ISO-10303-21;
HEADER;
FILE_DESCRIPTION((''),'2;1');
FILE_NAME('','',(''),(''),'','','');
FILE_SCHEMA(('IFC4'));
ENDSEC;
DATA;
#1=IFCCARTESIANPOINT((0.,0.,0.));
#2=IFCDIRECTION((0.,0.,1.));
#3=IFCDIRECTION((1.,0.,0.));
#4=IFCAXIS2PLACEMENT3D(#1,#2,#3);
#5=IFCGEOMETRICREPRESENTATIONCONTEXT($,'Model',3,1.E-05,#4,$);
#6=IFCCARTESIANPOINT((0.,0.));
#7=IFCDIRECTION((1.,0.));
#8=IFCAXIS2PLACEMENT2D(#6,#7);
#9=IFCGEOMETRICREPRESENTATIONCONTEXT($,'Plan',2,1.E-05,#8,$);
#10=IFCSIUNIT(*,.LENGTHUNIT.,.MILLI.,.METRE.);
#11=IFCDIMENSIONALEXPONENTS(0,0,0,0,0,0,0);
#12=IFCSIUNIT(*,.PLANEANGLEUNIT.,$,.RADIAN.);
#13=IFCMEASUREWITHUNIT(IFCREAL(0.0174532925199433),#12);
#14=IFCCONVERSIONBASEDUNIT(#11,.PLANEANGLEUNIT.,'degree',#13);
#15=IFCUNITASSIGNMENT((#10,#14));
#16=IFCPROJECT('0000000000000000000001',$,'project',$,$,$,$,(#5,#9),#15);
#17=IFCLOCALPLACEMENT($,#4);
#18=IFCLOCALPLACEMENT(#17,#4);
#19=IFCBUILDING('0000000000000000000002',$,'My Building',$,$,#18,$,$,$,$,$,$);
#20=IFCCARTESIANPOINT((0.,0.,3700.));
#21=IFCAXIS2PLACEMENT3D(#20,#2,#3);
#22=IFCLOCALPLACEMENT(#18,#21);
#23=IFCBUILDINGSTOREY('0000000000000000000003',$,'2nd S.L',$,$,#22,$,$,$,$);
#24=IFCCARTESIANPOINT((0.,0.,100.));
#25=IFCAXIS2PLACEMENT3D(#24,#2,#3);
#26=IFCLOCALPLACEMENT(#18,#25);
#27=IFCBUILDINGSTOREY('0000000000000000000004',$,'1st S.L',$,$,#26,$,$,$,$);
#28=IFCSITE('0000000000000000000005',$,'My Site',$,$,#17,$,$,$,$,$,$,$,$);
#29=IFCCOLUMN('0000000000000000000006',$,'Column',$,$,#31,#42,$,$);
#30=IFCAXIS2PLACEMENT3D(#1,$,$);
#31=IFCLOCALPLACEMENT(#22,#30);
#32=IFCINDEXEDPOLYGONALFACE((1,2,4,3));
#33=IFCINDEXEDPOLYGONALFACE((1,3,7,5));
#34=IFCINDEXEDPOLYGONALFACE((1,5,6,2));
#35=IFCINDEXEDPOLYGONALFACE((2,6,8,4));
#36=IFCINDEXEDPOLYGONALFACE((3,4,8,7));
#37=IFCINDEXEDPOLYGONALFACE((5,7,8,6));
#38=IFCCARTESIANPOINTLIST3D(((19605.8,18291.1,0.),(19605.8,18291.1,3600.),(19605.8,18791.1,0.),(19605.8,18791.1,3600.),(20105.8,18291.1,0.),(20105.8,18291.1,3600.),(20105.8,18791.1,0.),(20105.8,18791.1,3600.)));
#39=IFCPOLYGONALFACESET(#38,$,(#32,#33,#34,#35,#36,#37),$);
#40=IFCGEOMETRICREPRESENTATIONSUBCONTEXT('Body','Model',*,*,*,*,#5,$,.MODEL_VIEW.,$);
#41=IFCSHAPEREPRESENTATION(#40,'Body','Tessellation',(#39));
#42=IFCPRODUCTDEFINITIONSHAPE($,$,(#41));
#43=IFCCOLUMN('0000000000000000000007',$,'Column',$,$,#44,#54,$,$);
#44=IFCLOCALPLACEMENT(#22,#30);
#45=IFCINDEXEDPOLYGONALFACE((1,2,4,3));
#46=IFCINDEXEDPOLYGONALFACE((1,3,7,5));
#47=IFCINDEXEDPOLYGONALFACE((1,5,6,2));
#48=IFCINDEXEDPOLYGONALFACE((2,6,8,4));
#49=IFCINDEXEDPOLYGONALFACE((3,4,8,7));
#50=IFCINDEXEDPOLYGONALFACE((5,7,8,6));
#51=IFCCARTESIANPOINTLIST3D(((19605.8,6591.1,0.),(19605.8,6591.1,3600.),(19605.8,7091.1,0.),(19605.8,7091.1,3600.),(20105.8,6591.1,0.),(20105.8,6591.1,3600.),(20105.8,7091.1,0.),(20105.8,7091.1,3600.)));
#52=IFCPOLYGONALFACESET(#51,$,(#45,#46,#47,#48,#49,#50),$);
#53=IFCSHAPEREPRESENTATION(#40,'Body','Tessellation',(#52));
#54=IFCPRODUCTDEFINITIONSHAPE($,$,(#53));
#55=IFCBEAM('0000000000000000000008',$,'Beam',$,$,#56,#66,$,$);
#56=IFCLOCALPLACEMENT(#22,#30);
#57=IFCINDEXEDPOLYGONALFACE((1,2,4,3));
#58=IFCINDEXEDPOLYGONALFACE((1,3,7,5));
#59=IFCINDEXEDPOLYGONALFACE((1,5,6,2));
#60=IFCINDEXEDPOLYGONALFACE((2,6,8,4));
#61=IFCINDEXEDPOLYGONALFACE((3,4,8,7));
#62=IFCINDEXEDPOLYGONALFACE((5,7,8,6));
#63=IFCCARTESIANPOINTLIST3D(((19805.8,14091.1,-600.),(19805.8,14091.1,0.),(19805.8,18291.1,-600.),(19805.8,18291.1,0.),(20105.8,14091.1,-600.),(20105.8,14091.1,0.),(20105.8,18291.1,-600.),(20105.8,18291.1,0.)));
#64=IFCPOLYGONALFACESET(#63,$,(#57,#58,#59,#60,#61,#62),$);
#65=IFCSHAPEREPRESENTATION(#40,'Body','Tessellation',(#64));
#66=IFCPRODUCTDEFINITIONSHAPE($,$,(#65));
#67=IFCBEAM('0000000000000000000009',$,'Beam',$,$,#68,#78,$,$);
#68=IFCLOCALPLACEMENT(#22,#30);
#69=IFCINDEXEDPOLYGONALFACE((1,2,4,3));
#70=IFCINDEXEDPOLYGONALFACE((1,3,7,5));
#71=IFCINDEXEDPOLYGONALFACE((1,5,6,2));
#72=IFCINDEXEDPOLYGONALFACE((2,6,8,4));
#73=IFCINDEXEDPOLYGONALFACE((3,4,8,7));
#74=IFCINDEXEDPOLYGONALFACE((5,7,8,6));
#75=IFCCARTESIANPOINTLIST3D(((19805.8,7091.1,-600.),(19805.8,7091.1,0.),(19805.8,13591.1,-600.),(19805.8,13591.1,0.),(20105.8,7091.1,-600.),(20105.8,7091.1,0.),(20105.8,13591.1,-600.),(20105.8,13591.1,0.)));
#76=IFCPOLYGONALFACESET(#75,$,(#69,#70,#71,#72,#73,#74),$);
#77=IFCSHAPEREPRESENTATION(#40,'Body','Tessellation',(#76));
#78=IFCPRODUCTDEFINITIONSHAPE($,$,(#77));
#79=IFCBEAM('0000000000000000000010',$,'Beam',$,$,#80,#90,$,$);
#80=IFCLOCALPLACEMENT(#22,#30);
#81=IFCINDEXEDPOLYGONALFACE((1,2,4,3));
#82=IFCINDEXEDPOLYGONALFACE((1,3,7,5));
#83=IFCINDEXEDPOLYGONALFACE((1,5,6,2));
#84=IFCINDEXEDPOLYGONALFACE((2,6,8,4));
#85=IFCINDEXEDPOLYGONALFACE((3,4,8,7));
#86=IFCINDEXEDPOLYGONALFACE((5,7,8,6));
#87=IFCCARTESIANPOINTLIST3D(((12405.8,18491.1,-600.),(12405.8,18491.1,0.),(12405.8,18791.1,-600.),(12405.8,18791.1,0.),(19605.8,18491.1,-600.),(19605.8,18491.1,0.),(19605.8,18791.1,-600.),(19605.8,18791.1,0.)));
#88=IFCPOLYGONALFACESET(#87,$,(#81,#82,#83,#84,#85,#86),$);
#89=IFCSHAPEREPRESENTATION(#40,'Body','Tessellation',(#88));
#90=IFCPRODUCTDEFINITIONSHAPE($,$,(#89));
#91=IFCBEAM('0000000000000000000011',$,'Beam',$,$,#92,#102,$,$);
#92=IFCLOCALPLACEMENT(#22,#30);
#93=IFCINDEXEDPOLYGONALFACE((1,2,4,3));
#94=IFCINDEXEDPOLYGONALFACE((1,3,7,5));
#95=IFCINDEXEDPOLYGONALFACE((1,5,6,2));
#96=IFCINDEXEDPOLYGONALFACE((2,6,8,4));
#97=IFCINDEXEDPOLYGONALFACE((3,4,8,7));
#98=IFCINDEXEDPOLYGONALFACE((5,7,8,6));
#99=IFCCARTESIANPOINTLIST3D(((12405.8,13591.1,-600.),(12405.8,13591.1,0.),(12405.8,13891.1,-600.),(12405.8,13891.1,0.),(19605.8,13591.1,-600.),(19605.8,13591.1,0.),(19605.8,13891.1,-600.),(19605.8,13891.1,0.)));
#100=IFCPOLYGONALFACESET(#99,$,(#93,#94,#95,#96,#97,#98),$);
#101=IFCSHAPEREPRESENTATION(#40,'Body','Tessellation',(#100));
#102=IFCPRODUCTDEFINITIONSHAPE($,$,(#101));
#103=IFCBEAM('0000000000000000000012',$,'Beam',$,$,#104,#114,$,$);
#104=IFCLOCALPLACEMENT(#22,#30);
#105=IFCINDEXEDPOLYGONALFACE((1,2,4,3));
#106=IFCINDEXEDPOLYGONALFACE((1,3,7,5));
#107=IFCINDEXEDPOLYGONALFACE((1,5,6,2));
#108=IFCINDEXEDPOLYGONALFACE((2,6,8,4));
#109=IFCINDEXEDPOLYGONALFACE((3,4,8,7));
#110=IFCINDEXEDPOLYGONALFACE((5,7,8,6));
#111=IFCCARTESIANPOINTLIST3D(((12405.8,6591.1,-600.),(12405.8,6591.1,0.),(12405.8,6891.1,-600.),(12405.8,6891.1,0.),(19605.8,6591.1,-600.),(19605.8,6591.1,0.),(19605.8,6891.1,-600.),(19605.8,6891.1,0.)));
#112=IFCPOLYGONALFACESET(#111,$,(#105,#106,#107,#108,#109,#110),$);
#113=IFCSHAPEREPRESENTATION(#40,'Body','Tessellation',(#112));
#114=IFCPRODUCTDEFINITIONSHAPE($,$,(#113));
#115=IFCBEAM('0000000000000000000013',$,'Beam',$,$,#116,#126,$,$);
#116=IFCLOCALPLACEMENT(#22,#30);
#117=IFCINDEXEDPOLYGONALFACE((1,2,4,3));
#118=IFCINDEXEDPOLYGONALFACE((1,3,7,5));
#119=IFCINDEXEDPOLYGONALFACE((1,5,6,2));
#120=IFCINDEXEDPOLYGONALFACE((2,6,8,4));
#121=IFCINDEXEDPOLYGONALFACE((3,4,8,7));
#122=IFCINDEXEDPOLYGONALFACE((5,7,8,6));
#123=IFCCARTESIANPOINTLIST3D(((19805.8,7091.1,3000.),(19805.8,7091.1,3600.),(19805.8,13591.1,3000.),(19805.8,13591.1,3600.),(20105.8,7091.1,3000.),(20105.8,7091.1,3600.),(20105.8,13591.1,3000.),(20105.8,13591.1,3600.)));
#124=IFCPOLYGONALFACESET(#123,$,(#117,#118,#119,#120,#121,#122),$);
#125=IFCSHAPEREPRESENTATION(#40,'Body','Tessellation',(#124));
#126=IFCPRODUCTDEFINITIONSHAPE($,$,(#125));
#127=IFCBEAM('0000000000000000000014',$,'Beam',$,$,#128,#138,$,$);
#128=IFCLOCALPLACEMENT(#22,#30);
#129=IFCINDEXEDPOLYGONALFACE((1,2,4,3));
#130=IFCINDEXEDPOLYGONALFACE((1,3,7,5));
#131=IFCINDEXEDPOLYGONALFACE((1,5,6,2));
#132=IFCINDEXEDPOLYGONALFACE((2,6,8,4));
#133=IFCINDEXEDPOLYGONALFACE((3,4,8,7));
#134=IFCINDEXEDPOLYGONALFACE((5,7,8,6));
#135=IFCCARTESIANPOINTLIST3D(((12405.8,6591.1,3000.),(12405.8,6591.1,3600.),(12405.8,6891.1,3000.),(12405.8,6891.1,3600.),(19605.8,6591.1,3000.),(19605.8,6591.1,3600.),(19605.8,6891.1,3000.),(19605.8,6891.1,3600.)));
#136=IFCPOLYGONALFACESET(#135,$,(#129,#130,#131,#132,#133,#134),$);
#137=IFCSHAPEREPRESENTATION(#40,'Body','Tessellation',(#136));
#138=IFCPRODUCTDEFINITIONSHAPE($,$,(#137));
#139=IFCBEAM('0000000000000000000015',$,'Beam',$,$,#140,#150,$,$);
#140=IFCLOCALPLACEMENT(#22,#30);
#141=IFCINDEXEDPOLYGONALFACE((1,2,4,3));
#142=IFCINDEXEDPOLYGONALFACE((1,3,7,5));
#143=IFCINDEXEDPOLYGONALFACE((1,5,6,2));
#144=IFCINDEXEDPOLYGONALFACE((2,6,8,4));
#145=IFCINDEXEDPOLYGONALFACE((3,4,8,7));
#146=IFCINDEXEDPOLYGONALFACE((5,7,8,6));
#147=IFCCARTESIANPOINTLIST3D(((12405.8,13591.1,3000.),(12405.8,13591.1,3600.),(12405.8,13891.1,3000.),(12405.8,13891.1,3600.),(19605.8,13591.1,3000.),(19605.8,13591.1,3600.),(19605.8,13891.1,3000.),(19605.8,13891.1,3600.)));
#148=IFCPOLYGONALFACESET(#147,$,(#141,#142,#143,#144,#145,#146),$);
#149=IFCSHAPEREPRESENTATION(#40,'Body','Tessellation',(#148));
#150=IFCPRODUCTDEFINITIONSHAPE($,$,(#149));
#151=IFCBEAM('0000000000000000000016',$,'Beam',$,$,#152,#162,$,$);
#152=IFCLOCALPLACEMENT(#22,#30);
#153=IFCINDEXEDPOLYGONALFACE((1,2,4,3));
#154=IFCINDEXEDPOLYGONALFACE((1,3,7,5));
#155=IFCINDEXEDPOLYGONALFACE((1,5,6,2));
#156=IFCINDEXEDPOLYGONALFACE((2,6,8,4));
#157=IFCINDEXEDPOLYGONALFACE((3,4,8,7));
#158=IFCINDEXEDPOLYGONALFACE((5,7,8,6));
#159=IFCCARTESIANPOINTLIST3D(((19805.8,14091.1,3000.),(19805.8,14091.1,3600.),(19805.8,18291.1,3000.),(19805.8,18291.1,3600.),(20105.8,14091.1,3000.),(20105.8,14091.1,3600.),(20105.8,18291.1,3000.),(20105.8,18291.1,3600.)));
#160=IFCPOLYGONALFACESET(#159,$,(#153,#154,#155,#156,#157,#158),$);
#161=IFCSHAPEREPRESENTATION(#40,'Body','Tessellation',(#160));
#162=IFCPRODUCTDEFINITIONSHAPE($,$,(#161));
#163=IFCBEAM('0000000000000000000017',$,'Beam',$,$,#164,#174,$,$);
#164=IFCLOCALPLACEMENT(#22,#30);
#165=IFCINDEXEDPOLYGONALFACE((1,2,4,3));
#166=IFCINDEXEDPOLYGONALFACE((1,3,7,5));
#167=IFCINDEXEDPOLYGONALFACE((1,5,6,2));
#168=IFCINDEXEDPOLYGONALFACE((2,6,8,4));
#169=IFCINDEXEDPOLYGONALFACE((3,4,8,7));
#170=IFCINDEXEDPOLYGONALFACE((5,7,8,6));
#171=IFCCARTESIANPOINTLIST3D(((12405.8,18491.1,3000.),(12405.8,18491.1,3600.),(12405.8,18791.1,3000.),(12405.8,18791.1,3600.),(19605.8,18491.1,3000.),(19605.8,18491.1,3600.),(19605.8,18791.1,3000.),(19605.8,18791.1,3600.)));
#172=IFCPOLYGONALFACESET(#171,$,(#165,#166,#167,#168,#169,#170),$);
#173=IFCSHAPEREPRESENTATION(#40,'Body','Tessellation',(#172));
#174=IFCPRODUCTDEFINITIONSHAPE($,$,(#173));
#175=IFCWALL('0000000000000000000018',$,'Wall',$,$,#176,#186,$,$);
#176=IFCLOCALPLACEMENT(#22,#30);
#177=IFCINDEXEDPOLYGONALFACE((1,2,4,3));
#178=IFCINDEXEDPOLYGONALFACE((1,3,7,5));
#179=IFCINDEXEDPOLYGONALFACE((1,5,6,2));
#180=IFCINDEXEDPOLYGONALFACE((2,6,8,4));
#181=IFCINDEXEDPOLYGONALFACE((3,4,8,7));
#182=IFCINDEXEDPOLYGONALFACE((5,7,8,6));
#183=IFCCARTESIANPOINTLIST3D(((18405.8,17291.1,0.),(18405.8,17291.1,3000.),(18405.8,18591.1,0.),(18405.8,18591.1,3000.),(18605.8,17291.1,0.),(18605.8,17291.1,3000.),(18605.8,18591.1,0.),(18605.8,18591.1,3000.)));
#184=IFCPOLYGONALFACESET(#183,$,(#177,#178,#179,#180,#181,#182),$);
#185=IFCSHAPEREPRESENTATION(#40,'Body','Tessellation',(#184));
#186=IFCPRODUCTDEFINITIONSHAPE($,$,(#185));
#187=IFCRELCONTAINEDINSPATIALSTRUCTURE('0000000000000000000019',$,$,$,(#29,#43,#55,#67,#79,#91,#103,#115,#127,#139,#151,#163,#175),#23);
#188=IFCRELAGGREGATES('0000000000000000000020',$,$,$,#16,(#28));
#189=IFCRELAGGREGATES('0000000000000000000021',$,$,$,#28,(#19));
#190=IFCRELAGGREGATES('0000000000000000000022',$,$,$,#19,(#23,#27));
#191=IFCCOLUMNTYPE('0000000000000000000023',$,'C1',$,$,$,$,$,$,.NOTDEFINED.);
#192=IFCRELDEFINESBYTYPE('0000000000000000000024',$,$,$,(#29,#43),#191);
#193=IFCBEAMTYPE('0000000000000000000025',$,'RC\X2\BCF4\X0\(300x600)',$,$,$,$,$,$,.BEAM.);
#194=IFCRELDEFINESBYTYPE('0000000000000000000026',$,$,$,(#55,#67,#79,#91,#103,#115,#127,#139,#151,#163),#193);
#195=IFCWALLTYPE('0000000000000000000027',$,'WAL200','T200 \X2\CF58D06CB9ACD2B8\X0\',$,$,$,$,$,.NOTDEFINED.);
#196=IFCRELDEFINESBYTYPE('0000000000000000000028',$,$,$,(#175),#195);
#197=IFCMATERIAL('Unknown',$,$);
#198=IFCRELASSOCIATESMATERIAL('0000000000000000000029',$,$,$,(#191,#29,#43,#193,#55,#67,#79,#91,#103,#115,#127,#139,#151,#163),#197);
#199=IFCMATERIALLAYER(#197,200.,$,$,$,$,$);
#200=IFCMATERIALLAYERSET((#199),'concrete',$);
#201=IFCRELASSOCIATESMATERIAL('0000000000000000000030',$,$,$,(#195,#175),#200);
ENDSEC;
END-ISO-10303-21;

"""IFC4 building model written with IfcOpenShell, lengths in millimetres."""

from ifc_helpers import new_model, entity, si_unit, converted_unit, frame, origin_with_axes, origin_2d_with_axis, place, context, subcontext, project, spatial, indexed_curve, rectangle, outline, extrude, material, layer, layer_set, layer_usage, material_profile, profile_set, profile_usage, type_object, element, save


model = new_model("IFC4")

# Units and contexts
model_context = context("Model", 3, precision=1e-05, world=origin_with_axes())
plan_context = context("Plan", 2, precision=1e-05, world=origin_2d_with_axis())
body_context_1 = subcontext(model_context, "Body", "Model", "MODEL_VIEW")
ifc_project = project(units=[si_unit("LENGTHUNIT", "METRE", prefix="MILLI"), converted_unit("PLANEANGLEUNIT", "degree", entity("IfcReal", 0.0174532925199433), si_unit("PLANEANGLEUNIT", "RADIAN"), dimensions=[0, 0, 0, 0, 0, 0, 0])], contexts=[model_context, plan_context])

# Site, building, storey
site_placement = place(None, origin_with_axes())
site = spatial("IfcSite", under=ifc_project, at=site_placement, Name="My Site")
building_placement = place(site_placement, origin_with_axes())
building = spatial("IfcBuilding", under=site, at=building_placement, Name="My Building")
storey_1_placement = place(building_placement, frame((0.0, 0.0, 3700.0), z_axis=(0.0, 0.0, 1.0), x_axis=(1.0, 0.0, 0.0)))
storey_1 = spatial("IfcBuildingStorey", under=building, at=storey_1_placement, Name="2nd S.L")

# Columns
ifc_material_1 = material(Name="Unknown")
ifc_material_profile_1 = material_profile(ifc_material_1, rectangle(XDim=500.0, YDim=500.0, kind="CURVE"))
ifc_profile_set_1 = profile_set([ifc_material_profile_1], Name="concrete")
ifc_profile_usage_1 = profile_usage(ifc_profile_set_1, cardinal=5)
column_type = type_object("IfcColumnType", Name="C1", PredefinedType="NOTDEFINED", material=ifc_profile_set_1)
column_1_placement = place(storey_1_placement, frame((19855.8, 18541.1, 0.0), z_axis=(0.0, 0.0, 1.0), x_axis=(1.0, 0.0, 0.0)))
element("IfcColumn", 1, at=column_1_placement, inside=storey_1, type_object=column_type, material=ifc_profile_usage_1, Name="Column", context=body_context_1, shape_type="SweptSolid", body=[
    extrude(rectangle(XDim=500.0, YDim=500.0, kind="CURVE"), origin_with_axes(), (0.0, 0.0, 1.0), 3600.0),
])
ifc_profile_usage_2 = profile_usage(ifc_profile_set_1, cardinal=5)
column_2_placement = place(storey_1_placement, frame((19855.8, 6841.1, 0.0), z_axis=(0.0, 0.0, 1.0), x_axis=(1.0, 0.0, 0.0)))
element("IfcColumn", 2, at=column_2_placement, inside=storey_1, type_object=column_type, material=ifc_profile_usage_2, Name="Column", context=body_context_1, shape_type="SweptSolid", body=[
    extrude(rectangle(XDim=500.0, YDim=500.0, kind="CURVE"), origin_with_axes(), (0.0, 0.0, 1.0), 3600.0),
])

# Beams
ifc_material_profile_2 = material_profile(ifc_material_1, outline(indexed_curve([(-150.0, 300.0), (150.0, 300.0), (150.0, -300.0), (-150.0, -300.0), (-150.0, 300.0)])))
ifc_profile_set_2 = profile_set([ifc_material_profile_2], Name="concrete")
ifc_profile_usage_3 = profile_usage(ifc_profile_set_2, cardinal=5)
beam_type = type_object("IfcBeamType", Name="RC보(300x600)", PredefinedType="BEAM", material=ifc_profile_set_2)
beam_1_placement = place(storey_1_placement, frame((19955.8, 18291.1, -300.0), z_axis=(0.0, -1.0, 0.0), x_axis=(1.0, 0.0, 0.0)))
element("IfcBeam", 3, at=beam_1_placement, inside=storey_1, type_object=beam_type, material=ifc_profile_usage_3, Name="Beam", context=body_context_1, shape_type="SweptSolid", body=[
    extrude(outline(indexed_curve([(-150.0, 300.0), (150.0, 300.0), (150.0, -300.0), (-150.0, -300.0), (-150.0, 300.0)])), origin_with_axes(), (0.0, 0.0, 1.0), 4200.0),
])
ifc_profile_usage_4 = profile_usage(ifc_profile_set_2, cardinal=5)
beam_2_placement = place(storey_1_placement, frame((19955.8, 13591.1, -300.0), z_axis=(0.0, -1.0, 0.0), x_axis=(1.0, 0.0, 0.0)))
element("IfcBeam", 4, at=beam_2_placement, inside=storey_1, type_object=beam_type, material=ifc_profile_usage_4, Name="Beam", context=body_context_1, shape_type="SweptSolid", body=[
    extrude(outline(indexed_curve([(-150.0, 300.0), (150.0, 300.0), (150.0, -300.0), (-150.0, -300.0), (-150.0, 300.0)])), origin_with_axes(), (0.0, 0.0, 1.0), 6500.0),
])
ifc_profile_usage_5 = profile_usage(ifc_profile_set_2, cardinal=5)
beam_3_placement = place(storey_1_placement, frame((19605.8, 18641.1, -300.0), z_axis=(-1.0, 0.0, 0.0), x_axis=(0.0, -1.0, 0.0)))
element("IfcBeam", 5, at=beam_3_placement, inside=storey_1, type_object=beam_type, material=ifc_profile_usage_5, Name="Beam", context=body_context_1, shape_type="SweptSolid", body=[
    extrude(outline(indexed_curve([(-150.0, 300.0), (150.0, 300.0), (150.0, -300.0), (-150.0, -300.0), (-150.0, 300.0)])), origin_with_axes(), (0.0, 0.0, 1.0), 7200.0),
])
ifc_profile_usage_6 = profile_usage(ifc_profile_set_2, cardinal=5)
beam_4_placement = place(storey_1_placement, frame((19605.8, 13741.1, -300.0), z_axis=(-1.0, 0.0, 0.0), x_axis=(0.0, -1.0, 0.0)))
element("IfcBeam", 6, at=beam_4_placement, inside=storey_1, type_object=beam_type, material=ifc_profile_usage_6, Name="Beam", context=body_context_1, shape_type="SweptSolid", body=[
    extrude(outline(indexed_curve([(-150.0, 300.0), (150.0, 300.0), (150.0, -300.0), (-150.0, -300.0), (-150.0, 300.0)])), origin_with_axes(), (0.0, 0.0, 1.0), 7200.0),
])
ifc_profile_usage_7 = profile_usage(ifc_profile_set_2, cardinal=5)
beam_5_placement = place(storey_1_placement, frame((19605.8, 6741.1, -300.0), z_axis=(-1.0, 0.0, 0.0), x_axis=(0.0, -1.0, 0.0)))
element("IfcBeam", 7, at=beam_5_placement, inside=storey_1, type_object=beam_type, material=ifc_profile_usage_7, Name="Beam", context=body_context_1, shape_type="SweptSolid", body=[
    extrude(outline(indexed_curve([(-150.0, 300.0), (150.0, 300.0), (150.0, -300.0), (-150.0, -300.0), (-150.0, 300.0)])), origin_with_axes(), (0.0, 0.0, 1.0), 7200.0),
])
ifc_profile_usage_8 = profile_usage(ifc_profile_set_2, cardinal=5)
beam_6_placement = place(storey_1_placement, frame((19955.8, 13591.1, 3300.0), z_axis=(0.0, -1.0, 0.0), x_axis=(1.0, 0.0, 0.0)))
element("IfcBeam", 8, at=beam_6_placement, inside=storey_1, type_object=beam_type, material=ifc_profile_usage_8, Name="Beam", context=body_context_1, shape_type="SweptSolid", body=[
    extrude(outline(indexed_curve([(-150.0, 300.0), (150.0, 300.0), (150.0, -300.0), (-150.0, -300.0), (-150.0, 300.0)])), origin_with_axes(), (0.0, 0.0, 1.0), 6500.0),
])
ifc_profile_usage_9 = profile_usage(ifc_profile_set_2, cardinal=5)
beam_7_placement = place(storey_1_placement, frame((19605.8, 6741.1, 3300.0), z_axis=(-1.0, 0.0, 0.0), x_axis=(0.0, -1.0, 0.0)))
element("IfcBeam", 9, at=beam_7_placement, inside=storey_1, type_object=beam_type, material=ifc_profile_usage_9, Name="Beam", context=body_context_1, shape_type="SweptSolid", body=[
    extrude(outline(indexed_curve([(-150.0, 300.0), (150.0, 300.0), (150.0, -300.0), (-150.0, -300.0), (-150.0, 300.0)])), origin_with_axes(), (0.0, 0.0, 1.0), 7200.0),
])
ifc_profile_usage_10 = profile_usage(ifc_profile_set_2, cardinal=5)
beam_8_placement = place(storey_1_placement, frame((19605.8, 13741.1, 3300.0), z_axis=(-1.0, 0.0, 0.0), x_axis=(0.0, -1.0, 0.0)))
element("IfcBeam", 10, at=beam_8_placement, inside=storey_1, type_object=beam_type, material=ifc_profile_usage_10, Name="Beam", context=body_context_1, shape_type="SweptSolid", body=[
    extrude(outline(indexed_curve([(-150.0, 300.0), (150.0, 300.0), (150.0, -300.0), (-150.0, -300.0), (-150.0, 300.0)])), origin_with_axes(), (0.0, 0.0, 1.0), 7200.0),
])
ifc_profile_usage_11 = profile_usage(ifc_profile_set_2, cardinal=5)
beam_9_placement = place(storey_1_placement, frame((19955.8, 18291.1, 3300.0), z_axis=(0.0, -1.0, 0.0), x_axis=(1.0, 0.0, 0.0)))
element("IfcBeam", 11, at=beam_9_placement, inside=storey_1, type_object=beam_type, material=ifc_profile_usage_11, Name="Beam", context=body_context_1, shape_type="SweptSolid", body=[
    extrude(outline(indexed_curve([(-150.0, 300.0), (150.0, 300.0), (150.0, -300.0), (-150.0, -300.0), (-150.0, 300.0)])), origin_with_axes(), (0.0, 0.0, 1.0), 4200.0),
])
ifc_profile_usage_12 = profile_usage(ifc_profile_set_2, cardinal=5)
beam_10_placement = place(storey_1_placement, frame((19605.8, 18641.1, 3300.0), z_axis=(-1.0, 0.0, 0.0), x_axis=(0.0, -1.0, 0.0)))
element("IfcBeam", 12, at=beam_10_placement, inside=storey_1, type_object=beam_type, material=ifc_profile_usage_12, Name="Beam", context=body_context_1, shape_type="SolidModel", body=[
    extrude(outline(indexed_curve([(-150.0, 300.0), (150.0, 300.0), (150.0, -300.0), (-150.0, -300.0), (-150.0, 300.0)])), origin_with_axes(), (0.0, 0.0, 1.0), 7200.0),
])

# Wall
ifc_layer = layer(ifc_material_1, 200.0)
ifc_layer_set = layer_set([ifc_layer], Name="concrete")
ifc_layer_usage_1 = layer_usage(ifc_layer_set, "AXIS2", "POSITIVE", 0.0)
wall_type = type_object("IfcWallType", Name="WAL200", Description="T200 콘크리트", PredefinedType="NOTDEFINED", material=ifc_layer_set)
wall_1_placement = place(storey_1_placement, frame((18605.8, 17291.1, 0.0), z_axis=(0.0, 0.0, 1.0), x_axis=(0.0, 1.0, 0.0)))
element("IfcWall", 13, at=wall_1_placement, inside=storey_1, type_object=wall_type, material=ifc_layer_usage_1, Name="Wall", context=body_context_1, shape_type="SweptSolid", body=[
    extrude(outline(indexed_curve([(0.0, 0.0), (0.0, 200.0), (1300.0, 200.0), (1300.0, 0.0), (0.0, 0.0)], self_intersect=False)), origin_with_axes(), (0.0, 0.0, 1.0), 3000.0),
])

# Shared definitions
storey_2_placement = place(building_placement, frame((0.0, 0.0, 100.0), z_axis=(0.0, 0.0, 1.0), x_axis=(1.0, 0.0, 0.0)))
storey_2 = spatial("IfcBuildingStorey", under=building, at=storey_2_placement, Name="1st S.L")

save(model, "model.ifc")
